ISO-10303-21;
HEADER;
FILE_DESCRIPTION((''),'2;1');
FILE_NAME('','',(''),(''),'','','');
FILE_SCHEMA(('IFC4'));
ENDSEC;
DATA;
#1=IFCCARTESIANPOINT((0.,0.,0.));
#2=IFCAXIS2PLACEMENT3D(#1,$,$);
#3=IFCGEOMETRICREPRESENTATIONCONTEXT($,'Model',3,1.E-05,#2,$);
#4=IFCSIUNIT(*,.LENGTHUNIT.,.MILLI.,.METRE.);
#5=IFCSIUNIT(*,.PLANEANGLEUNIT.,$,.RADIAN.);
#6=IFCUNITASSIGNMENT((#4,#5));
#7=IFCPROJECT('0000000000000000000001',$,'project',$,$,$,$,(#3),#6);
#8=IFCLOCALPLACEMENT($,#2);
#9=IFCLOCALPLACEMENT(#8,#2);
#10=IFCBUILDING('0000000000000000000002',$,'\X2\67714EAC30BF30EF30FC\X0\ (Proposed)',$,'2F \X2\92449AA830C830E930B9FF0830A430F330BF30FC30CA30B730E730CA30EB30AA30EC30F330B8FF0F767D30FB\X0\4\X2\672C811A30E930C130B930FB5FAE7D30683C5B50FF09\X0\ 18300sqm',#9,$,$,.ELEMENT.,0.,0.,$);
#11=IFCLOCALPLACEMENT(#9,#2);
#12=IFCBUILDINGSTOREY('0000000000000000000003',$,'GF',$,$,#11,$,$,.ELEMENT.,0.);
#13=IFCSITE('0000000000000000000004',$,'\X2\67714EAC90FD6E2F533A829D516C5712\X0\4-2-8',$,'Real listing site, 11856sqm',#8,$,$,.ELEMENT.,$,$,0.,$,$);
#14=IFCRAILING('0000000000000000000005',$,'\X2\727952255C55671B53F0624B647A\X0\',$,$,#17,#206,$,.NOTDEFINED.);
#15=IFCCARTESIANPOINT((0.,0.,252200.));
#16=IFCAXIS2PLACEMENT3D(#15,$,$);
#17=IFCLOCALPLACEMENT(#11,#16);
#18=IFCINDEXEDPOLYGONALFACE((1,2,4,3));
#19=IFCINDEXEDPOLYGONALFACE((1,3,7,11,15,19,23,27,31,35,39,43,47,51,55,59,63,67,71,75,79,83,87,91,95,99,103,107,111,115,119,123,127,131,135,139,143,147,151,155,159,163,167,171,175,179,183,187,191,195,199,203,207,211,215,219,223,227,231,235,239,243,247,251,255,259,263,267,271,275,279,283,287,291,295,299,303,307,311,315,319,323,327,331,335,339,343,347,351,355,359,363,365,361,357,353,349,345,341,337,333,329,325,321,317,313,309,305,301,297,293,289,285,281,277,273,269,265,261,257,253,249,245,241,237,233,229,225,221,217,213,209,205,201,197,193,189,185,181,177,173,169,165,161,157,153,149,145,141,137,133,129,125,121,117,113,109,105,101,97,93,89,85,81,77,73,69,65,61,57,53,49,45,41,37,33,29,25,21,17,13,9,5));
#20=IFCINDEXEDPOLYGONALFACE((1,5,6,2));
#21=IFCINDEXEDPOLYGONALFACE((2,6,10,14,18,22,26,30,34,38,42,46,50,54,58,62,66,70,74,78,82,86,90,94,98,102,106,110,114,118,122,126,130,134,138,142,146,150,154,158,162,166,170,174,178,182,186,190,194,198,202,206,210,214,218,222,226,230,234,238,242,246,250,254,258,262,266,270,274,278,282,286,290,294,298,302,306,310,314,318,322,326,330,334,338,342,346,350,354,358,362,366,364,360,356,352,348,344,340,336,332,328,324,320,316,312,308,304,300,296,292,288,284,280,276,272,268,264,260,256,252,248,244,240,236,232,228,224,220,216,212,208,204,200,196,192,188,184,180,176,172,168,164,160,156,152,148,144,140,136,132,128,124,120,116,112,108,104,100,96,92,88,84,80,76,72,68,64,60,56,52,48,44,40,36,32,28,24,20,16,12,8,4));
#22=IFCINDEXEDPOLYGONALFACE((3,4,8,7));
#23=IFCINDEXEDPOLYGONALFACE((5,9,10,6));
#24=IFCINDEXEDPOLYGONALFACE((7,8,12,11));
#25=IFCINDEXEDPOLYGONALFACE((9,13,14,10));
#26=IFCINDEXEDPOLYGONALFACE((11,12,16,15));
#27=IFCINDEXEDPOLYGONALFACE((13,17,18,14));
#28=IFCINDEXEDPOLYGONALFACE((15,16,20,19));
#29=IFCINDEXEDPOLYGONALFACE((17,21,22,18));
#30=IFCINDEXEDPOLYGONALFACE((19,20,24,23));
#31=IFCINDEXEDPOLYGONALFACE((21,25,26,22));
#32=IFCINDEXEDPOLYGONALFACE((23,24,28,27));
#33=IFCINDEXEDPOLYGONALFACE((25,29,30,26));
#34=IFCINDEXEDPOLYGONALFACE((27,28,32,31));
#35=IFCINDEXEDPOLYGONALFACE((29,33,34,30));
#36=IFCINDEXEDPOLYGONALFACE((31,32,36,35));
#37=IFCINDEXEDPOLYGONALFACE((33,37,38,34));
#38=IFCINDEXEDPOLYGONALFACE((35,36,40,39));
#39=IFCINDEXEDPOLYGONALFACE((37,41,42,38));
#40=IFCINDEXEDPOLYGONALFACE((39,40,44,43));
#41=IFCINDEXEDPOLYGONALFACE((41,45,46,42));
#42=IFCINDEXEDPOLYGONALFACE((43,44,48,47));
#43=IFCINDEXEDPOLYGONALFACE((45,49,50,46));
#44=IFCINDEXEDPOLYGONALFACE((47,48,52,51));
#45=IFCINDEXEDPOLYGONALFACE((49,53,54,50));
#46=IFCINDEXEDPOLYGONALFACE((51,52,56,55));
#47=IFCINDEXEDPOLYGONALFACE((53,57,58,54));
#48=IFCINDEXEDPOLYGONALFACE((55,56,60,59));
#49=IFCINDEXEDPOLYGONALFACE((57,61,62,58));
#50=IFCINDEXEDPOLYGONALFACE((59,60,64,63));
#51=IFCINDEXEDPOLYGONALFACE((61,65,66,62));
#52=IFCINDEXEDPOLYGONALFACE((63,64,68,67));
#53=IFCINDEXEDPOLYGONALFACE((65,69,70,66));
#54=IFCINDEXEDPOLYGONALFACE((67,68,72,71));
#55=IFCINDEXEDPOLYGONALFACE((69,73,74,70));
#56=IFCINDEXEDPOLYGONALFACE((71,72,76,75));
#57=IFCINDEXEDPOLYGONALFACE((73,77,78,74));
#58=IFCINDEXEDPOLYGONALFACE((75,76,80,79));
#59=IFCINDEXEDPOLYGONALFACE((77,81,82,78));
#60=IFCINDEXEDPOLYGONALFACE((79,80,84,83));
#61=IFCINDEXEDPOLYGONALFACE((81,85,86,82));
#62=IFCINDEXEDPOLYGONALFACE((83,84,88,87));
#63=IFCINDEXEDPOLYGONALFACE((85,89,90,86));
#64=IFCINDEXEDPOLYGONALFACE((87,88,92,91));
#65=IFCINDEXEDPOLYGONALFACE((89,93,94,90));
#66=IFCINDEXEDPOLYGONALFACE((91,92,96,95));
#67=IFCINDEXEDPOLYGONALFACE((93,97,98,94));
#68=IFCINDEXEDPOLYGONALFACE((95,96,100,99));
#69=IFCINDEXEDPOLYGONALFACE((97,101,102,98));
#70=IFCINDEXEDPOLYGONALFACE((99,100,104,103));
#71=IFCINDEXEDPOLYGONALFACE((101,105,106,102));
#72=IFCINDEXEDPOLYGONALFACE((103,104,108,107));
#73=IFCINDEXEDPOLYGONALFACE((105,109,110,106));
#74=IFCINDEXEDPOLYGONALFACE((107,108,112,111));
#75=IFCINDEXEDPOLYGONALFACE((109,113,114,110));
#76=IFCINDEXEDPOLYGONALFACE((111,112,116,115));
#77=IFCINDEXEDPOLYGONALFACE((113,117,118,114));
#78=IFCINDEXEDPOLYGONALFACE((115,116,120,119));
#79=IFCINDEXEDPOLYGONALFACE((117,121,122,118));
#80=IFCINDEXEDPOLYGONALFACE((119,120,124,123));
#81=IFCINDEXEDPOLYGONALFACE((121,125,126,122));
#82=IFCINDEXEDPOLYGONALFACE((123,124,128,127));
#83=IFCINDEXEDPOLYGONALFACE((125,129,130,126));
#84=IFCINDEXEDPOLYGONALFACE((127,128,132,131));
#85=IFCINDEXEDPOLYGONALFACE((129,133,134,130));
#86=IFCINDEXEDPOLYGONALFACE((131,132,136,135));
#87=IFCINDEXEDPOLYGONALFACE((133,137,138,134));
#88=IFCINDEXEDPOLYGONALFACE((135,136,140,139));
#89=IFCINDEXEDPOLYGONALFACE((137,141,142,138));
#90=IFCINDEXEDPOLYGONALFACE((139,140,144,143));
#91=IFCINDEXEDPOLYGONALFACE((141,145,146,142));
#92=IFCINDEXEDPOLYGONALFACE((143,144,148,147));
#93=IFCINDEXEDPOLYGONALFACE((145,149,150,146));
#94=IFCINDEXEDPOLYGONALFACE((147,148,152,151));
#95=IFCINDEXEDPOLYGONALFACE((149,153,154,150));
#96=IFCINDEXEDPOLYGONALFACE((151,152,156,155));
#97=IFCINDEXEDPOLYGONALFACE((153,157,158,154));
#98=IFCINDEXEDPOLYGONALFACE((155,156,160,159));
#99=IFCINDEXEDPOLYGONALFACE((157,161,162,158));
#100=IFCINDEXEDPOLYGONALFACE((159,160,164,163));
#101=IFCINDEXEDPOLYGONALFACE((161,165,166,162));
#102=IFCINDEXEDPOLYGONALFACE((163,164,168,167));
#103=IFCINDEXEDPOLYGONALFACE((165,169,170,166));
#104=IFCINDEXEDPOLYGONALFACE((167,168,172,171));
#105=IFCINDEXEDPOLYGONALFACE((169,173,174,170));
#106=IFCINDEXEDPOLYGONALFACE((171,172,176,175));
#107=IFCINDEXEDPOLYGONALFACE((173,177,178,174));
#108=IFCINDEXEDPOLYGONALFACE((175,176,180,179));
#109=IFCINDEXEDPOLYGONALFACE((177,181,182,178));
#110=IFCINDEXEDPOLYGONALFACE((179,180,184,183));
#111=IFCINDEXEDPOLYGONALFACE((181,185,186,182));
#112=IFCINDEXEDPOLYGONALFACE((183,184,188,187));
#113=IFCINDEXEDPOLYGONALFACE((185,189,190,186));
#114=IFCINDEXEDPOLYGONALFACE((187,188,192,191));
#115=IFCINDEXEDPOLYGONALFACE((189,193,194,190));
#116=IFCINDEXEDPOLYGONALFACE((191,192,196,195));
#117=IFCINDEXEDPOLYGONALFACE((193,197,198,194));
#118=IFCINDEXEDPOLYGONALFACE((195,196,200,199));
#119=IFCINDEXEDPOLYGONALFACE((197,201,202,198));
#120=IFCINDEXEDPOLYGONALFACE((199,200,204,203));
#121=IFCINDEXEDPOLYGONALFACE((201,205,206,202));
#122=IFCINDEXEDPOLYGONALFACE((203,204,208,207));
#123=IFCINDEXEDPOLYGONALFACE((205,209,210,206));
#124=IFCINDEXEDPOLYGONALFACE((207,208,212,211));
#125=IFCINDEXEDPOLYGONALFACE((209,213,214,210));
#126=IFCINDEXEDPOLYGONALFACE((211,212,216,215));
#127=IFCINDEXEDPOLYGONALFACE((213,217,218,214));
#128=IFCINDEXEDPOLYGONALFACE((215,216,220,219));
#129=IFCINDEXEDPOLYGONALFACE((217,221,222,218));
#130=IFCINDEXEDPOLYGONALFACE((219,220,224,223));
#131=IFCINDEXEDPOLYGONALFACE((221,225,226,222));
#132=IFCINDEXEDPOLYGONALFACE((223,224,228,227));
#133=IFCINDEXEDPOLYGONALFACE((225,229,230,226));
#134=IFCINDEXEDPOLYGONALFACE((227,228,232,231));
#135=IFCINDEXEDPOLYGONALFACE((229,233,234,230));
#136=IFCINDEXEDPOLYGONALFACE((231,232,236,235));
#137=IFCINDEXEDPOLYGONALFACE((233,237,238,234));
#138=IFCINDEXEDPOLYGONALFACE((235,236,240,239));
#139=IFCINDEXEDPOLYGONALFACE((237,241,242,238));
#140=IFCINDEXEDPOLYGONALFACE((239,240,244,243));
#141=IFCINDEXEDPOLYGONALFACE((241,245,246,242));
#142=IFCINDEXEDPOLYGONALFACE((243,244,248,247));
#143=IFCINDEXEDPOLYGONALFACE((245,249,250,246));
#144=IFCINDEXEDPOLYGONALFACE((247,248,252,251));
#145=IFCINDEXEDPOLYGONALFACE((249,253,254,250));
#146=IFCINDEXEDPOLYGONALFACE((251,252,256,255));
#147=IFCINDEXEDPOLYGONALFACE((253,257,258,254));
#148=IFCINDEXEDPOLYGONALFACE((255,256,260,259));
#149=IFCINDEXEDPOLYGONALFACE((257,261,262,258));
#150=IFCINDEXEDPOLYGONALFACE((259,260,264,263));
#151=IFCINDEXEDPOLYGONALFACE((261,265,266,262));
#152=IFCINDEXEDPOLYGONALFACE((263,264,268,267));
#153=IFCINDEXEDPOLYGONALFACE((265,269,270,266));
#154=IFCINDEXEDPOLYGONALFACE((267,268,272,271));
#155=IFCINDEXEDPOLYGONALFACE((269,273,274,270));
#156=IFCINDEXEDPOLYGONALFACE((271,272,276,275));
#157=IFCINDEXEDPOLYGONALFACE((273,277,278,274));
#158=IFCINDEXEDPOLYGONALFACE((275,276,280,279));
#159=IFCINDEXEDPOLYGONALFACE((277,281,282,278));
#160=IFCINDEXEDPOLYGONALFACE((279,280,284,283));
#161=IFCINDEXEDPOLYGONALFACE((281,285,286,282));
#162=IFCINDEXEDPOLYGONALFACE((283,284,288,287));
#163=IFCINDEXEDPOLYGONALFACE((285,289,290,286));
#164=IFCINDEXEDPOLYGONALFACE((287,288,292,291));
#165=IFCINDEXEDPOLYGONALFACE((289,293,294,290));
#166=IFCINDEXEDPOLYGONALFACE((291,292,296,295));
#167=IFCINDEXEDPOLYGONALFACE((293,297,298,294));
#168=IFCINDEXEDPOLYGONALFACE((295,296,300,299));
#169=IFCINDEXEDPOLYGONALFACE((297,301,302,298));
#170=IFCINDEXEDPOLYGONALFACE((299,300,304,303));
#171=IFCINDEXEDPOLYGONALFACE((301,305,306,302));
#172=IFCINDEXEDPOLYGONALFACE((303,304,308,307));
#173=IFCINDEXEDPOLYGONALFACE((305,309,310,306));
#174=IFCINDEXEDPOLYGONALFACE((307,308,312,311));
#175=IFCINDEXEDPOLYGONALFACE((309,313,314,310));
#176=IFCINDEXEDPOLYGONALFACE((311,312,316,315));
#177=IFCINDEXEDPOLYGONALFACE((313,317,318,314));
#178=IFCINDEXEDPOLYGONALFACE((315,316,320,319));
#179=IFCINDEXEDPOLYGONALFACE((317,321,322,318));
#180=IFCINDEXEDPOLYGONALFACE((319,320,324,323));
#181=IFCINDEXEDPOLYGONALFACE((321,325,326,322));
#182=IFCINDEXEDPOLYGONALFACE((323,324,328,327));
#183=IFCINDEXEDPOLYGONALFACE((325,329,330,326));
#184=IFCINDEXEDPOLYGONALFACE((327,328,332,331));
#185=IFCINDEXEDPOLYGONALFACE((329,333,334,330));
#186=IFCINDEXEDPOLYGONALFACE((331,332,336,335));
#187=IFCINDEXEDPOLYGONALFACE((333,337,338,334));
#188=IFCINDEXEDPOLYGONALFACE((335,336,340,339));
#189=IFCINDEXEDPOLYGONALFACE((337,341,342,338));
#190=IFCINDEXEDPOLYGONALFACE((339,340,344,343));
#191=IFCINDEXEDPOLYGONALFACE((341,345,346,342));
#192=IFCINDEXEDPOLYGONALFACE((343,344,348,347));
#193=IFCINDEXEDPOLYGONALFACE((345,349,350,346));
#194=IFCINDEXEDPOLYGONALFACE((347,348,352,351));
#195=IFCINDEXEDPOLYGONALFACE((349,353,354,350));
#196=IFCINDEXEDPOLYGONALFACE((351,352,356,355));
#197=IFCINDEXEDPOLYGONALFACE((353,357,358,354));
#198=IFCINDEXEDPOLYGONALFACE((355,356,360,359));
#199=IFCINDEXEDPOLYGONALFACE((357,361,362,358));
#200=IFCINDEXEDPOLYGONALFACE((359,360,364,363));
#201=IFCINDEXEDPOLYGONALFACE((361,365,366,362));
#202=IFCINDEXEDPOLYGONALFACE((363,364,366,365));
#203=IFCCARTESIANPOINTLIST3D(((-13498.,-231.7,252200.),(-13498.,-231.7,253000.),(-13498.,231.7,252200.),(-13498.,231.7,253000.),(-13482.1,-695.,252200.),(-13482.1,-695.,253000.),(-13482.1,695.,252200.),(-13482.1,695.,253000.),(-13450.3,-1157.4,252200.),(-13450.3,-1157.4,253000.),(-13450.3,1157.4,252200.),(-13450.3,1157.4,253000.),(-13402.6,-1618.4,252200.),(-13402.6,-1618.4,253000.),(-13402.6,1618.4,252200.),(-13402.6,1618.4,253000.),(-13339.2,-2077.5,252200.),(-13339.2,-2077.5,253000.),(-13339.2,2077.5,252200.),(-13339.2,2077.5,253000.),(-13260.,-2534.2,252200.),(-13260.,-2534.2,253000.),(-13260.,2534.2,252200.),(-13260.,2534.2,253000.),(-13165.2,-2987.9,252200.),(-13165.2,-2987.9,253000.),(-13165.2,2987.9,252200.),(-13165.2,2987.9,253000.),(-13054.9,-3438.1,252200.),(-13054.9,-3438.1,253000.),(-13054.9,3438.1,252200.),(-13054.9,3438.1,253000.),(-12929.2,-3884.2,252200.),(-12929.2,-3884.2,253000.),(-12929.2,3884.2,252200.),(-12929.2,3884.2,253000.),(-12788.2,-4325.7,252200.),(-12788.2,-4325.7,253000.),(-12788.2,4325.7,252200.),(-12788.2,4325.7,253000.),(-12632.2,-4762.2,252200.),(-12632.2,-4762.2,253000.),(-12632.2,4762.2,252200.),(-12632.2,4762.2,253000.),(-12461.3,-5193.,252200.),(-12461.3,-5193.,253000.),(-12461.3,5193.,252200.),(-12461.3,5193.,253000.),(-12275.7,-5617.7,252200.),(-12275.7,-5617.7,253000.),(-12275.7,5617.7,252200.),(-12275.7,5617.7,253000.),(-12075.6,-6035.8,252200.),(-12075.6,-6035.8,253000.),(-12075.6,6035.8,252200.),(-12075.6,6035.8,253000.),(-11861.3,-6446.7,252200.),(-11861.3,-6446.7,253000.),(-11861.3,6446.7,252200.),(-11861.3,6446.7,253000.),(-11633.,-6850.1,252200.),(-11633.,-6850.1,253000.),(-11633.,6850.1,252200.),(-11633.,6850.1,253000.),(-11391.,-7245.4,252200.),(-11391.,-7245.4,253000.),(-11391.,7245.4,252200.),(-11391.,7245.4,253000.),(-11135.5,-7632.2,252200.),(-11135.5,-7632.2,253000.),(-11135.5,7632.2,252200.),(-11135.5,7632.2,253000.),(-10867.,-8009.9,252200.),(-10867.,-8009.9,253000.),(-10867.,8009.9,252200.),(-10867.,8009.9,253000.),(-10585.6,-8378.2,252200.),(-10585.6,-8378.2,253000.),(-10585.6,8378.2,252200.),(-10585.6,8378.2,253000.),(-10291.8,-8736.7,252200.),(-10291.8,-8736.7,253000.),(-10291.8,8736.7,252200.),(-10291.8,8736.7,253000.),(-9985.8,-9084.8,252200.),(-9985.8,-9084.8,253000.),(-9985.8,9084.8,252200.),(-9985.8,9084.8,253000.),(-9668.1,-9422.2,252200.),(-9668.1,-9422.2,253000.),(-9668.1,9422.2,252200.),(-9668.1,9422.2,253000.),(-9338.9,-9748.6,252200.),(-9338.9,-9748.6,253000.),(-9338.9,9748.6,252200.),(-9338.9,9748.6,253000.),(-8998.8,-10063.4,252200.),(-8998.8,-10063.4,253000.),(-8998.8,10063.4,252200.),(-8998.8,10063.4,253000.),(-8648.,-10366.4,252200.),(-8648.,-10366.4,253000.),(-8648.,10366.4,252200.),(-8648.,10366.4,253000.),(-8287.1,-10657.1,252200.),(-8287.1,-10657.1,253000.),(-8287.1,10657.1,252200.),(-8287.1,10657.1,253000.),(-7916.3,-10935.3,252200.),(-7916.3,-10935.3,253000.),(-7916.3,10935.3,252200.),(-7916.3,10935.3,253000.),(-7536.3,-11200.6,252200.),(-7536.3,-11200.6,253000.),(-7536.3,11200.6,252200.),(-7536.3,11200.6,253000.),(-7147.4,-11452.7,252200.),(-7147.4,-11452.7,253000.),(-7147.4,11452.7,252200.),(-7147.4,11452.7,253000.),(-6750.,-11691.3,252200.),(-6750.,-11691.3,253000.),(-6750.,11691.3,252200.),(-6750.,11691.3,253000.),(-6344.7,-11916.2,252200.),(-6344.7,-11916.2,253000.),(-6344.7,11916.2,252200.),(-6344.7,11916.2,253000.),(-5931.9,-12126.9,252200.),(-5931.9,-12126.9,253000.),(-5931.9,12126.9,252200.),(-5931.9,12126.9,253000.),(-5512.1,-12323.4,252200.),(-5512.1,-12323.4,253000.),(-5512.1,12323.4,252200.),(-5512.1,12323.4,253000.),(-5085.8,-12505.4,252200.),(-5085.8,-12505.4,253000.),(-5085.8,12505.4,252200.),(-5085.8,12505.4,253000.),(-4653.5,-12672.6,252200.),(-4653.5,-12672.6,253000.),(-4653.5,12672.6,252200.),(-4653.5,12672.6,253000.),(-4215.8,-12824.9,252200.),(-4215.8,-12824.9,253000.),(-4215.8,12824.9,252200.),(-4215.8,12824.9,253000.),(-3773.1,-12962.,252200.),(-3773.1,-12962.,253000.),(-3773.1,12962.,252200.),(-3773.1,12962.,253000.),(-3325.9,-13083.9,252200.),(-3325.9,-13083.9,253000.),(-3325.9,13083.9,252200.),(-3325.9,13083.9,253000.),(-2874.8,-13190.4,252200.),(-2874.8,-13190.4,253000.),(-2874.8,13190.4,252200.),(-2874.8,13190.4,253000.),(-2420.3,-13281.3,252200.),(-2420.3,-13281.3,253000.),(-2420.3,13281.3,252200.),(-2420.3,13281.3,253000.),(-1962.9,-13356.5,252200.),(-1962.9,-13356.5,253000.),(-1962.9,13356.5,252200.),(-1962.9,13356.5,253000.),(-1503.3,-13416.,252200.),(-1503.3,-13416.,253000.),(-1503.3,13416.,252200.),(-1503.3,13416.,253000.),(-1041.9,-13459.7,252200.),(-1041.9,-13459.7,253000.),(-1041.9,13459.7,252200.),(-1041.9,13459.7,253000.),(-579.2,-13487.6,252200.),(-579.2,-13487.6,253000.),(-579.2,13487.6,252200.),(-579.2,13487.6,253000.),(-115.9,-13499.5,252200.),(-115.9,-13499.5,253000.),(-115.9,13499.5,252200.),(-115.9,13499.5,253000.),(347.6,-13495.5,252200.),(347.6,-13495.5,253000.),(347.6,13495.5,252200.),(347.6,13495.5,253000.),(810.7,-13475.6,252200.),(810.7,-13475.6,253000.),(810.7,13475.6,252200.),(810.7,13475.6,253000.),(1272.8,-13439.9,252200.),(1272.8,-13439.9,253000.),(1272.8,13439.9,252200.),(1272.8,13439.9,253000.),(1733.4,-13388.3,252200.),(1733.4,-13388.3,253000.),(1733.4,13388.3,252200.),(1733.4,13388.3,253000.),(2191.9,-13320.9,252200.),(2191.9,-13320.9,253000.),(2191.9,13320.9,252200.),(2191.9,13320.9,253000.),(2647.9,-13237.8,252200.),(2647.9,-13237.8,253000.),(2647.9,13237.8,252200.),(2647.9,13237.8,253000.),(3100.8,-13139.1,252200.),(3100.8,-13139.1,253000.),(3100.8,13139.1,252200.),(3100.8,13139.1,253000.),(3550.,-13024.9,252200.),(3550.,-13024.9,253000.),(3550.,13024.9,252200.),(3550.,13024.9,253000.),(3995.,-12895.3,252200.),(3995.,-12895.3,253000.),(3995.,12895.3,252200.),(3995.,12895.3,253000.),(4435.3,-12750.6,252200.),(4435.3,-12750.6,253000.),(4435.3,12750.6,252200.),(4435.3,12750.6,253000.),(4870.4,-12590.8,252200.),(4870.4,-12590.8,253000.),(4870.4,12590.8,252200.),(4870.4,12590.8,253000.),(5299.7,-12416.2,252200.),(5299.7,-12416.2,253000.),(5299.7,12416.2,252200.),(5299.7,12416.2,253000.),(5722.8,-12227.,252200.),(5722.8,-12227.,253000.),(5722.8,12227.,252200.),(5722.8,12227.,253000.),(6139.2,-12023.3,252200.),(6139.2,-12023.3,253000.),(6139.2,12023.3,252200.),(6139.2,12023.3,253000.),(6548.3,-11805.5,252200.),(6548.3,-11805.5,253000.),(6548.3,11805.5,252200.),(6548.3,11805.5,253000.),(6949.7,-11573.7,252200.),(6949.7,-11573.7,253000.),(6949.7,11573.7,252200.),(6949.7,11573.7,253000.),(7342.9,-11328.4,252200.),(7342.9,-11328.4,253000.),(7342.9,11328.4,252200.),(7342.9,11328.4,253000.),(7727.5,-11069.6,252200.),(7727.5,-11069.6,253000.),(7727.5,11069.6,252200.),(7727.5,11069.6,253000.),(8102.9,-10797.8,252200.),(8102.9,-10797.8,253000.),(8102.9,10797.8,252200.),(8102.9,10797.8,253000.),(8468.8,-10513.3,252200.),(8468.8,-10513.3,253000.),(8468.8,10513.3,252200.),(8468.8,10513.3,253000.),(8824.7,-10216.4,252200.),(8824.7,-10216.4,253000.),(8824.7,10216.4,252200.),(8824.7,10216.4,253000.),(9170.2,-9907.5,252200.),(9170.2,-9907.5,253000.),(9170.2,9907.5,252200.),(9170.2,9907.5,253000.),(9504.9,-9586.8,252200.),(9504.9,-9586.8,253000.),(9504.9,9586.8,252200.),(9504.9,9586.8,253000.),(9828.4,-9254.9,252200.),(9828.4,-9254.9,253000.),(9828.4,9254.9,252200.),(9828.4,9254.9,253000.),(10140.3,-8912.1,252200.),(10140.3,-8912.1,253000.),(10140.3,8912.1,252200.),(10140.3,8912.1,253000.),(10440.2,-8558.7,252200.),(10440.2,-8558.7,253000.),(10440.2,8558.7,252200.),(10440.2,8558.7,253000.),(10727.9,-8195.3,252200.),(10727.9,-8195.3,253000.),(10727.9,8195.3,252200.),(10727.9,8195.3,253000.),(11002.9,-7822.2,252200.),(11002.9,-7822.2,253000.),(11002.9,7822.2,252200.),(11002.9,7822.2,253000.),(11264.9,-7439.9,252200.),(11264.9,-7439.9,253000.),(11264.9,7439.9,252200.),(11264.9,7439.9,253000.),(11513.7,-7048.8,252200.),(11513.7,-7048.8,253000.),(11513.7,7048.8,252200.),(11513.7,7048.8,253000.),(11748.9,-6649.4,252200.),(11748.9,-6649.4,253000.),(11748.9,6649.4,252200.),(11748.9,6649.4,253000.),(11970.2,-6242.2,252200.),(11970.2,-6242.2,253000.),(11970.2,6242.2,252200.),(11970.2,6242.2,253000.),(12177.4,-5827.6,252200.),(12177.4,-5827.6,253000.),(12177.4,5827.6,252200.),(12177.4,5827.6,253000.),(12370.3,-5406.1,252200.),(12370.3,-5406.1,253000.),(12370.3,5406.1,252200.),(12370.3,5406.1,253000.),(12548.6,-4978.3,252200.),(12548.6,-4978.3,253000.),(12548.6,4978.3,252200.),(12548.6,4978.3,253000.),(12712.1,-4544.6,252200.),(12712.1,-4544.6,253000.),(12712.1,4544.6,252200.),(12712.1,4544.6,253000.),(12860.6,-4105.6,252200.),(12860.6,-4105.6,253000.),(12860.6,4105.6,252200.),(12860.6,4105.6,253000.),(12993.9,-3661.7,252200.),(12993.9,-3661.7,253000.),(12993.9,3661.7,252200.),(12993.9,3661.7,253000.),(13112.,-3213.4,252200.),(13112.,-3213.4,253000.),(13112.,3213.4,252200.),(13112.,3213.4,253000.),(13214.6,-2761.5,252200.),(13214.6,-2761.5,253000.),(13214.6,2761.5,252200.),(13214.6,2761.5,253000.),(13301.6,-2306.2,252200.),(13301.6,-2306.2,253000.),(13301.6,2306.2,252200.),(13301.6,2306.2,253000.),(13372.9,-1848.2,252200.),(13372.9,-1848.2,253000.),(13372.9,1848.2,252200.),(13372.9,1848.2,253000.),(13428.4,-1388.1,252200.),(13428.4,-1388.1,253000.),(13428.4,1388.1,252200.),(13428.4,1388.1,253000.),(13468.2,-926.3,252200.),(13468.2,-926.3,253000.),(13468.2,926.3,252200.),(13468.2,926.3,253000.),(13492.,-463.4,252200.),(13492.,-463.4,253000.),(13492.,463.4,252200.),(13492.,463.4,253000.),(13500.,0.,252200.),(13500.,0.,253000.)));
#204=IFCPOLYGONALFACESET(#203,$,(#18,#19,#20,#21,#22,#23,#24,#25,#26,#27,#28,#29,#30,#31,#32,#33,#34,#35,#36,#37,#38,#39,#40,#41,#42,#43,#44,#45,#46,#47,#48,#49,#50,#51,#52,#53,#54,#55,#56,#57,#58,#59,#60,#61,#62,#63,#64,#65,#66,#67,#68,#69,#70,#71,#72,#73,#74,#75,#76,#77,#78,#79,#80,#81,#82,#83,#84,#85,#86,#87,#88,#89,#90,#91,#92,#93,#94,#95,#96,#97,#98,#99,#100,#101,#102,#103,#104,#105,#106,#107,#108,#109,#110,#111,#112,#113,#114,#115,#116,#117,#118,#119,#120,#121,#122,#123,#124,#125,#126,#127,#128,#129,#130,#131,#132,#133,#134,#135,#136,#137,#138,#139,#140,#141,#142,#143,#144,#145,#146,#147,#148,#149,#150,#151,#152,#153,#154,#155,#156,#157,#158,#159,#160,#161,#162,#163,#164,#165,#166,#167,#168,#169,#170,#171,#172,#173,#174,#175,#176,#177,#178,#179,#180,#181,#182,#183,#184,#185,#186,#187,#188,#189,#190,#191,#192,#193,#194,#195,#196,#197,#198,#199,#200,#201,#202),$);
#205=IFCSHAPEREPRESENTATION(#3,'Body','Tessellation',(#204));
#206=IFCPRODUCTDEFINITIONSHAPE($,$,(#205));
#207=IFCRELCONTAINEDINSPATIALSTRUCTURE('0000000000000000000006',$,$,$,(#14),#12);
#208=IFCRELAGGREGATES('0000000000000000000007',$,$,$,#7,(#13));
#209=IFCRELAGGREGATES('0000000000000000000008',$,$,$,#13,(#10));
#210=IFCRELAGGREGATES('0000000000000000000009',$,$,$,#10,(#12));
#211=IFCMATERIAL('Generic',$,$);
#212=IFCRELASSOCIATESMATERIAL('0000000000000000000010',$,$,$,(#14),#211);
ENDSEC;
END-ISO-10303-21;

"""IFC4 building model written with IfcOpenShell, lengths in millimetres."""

from ifc_helpers import new_model, si_unit, frame, origin, origin_2d, place, context, project, spatial, circle, extrude, material, element, save


model = new_model("IFC4")

# Units and contexts
model_context = context("Model", 3, precision=1e-05, world=origin())
ifc_project = project(units=[si_unit("LENGTHUNIT", "METRE", prefix="MILLI"), si_unit("PLANEANGLEUNIT", "RADIAN")], contexts=[model_context])

# Site, building, storey
site_placement = place(None, origin())
site = spatial("IfcSite", under=ifc_project, at=site_placement, Name="東京都港区芝公園4-2-8", ObjectType="Real listing site, 11856sqm", CompositionType="ELEMENT", RefElevation=0.0)
building_placement = place(site_placement, origin())
building = spatial("IfcBuilding", under=site, at=building_placement, Name="東京タワー (Proposed)", ObjectType="2F 鉄骨トラス（インターナショナルオレンジ／白・4本脚ラチス・微細格子） 18300sqm", CompositionType="ELEMENT", ElevationOfRefHeight=0.0, ElevationOfTerrain=0.0)
storey_placement = place(building_placement, origin())
storey = spatial("IfcBuildingStorey", under=building, at=storey_placement, Name="GF", CompositionType="ELEMENT", Elevation=0.0)

# Shared definitions
ifc_material = material(Name="Generic")

# Railing
railing_placement = place(storey_placement, frame((0.0, 0.0, 252200.0)))
element("IfcRailing", 1, at=railing_placement, inside=storey, material=ifc_material, Name="特別展望台手摺", PredefinedType="NOTDEFINED", context=model_context, shape_type="SweptSolid", body=[
    extrude(circle(Radius=13500.0, at=origin_2d()), frame((0.0, 0.0, 252200.0)), (0.0, 0.0, 1.0), 800.0),
])

save(model, "model.ifc")
